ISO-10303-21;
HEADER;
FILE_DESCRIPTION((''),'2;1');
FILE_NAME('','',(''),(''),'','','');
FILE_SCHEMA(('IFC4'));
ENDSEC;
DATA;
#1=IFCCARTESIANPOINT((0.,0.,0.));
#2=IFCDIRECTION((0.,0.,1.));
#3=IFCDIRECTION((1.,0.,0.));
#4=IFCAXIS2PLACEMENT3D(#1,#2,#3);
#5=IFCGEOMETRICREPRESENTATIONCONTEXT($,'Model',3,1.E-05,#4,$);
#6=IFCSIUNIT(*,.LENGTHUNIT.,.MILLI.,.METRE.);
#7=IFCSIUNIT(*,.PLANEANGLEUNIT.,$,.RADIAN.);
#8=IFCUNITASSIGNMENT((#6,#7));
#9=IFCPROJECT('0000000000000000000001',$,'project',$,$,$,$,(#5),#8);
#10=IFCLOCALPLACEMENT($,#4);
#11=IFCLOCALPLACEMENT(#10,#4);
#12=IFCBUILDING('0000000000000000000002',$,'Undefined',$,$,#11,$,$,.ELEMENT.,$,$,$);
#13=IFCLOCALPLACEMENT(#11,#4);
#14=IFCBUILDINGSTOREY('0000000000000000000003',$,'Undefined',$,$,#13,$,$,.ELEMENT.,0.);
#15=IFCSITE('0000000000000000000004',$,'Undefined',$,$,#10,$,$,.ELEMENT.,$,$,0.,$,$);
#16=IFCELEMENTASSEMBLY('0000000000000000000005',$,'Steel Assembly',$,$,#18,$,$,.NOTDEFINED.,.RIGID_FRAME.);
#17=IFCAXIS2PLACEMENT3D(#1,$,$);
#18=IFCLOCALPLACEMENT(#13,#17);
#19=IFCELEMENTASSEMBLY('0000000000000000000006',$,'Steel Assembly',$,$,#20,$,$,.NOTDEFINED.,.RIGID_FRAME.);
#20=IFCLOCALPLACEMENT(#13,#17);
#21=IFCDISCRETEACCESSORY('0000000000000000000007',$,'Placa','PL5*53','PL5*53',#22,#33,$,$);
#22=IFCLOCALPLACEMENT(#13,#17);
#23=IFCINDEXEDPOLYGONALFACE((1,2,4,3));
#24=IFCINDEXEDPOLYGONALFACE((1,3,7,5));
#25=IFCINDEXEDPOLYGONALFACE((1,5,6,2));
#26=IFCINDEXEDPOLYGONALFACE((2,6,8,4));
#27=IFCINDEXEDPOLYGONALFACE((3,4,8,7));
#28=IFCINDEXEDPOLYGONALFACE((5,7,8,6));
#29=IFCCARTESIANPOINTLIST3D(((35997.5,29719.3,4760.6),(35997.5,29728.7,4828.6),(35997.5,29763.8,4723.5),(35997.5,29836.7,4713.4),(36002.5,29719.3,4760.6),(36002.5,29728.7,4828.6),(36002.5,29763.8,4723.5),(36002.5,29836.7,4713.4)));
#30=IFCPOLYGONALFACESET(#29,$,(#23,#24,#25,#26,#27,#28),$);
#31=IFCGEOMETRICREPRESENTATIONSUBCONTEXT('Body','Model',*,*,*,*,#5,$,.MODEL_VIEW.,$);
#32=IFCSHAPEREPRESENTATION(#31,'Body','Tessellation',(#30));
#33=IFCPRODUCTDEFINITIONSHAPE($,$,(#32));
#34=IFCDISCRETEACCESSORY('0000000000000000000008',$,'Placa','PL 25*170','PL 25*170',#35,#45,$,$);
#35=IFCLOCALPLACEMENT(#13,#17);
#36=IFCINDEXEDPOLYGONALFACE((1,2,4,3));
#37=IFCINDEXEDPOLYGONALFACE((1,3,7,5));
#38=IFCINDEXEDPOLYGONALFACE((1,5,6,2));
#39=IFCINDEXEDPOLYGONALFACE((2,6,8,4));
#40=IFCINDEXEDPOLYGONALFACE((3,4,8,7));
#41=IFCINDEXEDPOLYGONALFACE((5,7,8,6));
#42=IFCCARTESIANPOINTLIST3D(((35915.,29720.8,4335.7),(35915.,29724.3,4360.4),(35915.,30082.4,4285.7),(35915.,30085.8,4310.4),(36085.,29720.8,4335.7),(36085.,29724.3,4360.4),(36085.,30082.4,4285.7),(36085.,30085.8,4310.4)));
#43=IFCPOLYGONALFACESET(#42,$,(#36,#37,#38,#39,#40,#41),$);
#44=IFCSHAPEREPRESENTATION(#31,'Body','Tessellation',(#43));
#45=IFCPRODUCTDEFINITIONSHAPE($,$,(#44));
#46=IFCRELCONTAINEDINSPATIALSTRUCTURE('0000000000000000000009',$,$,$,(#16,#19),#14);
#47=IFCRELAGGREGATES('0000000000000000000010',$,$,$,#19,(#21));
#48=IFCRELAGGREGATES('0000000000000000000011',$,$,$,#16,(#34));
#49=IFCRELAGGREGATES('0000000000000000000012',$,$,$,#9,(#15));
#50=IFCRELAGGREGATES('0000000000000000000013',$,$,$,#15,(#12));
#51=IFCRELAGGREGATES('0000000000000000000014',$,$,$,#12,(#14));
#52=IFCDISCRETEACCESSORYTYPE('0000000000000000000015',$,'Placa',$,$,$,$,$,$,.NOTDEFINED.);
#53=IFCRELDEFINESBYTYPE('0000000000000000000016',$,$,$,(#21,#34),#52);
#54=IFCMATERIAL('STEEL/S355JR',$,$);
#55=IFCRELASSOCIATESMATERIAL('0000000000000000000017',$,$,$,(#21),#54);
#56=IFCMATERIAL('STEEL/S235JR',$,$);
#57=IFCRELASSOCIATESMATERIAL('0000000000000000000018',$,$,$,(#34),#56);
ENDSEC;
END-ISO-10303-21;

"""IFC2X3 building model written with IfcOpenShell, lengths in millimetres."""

from ifc_helpers import new_model, si_unit, frame, origin_with_axes, place, context, subcontext, project, spatial, polyline, outline, extrude, material, type_object, element, aggregate, save


model = new_model("IFC2X3")

# Units and contexts
model_context = context("Model", 3, precision=1e-05, world=origin_with_axes())
body_context = subcontext(model_context, "Body", "Model", "MODEL_VIEW")
ifc_project = project(units=[si_unit("LENGTHUNIT", "METRE", prefix="MILLI"), si_unit("PLANEANGLEUNIT", "RADIAN")], contexts=[model_context])

# Site, building, storey
site_placement = place(None, origin_with_axes())
site = spatial("IfcSite", under=ifc_project, at=site_placement, Name="Undefined", CompositionType="ELEMENT", RefElevation=0.0)
building_placement = place(site_placement, origin_with_axes())
building = spatial("IfcBuilding", under=site, at=building_placement, Name="Undefined", CompositionType="ELEMENT")
storey_placement = place(building_placement, origin_with_axes())
storey = spatial("IfcBuildingStorey", under=building, at=storey_placement, Name="Undefined", CompositionType="ELEMENT", Elevation=0.0)

# Shared definitions
ifc_material_1 = material(Name="STEEL/S355JR")

# Element assembly
assembly_1_placement = place(storey_placement, origin_with_axes())
assembly_1 = element("IfcElementAssembly", 1, at=assembly_1_placement, inside=storey, Name="Steel Assembly", AssemblyPlace="NOTDEFINED", PredefinedType="RIGID_FRAME")

# Shared definitions
ifc_material_2 = material(Name="STEEL/S235JR")

# Element assembly, discrete accessory
assembly_2_placement = place(storey_placement, origin_with_axes())
assembly_2 = element("IfcElementAssembly", 2, at=assembly_2_placement, inside=storey, Name="Steel Assembly", AssemblyPlace="NOTDEFINED", PredefinedType="RIGID_FRAME")
discrete_accessory_type_1 = type_object("IfcDiscreteAccessoryType", Name="Placa")
discrete_accessory_1_placement = place(assembly_2_placement, frame((36000.0, 29728.7, 4828.6), z_axis=(-1.0, 0.0, 0.0), x_axis=(0.0, 0.684057, -0.729429)))
discrete_accessory_1 = element("IfcDiscreteAccessory", 3, at=discrete_accessory_1_placement, type_object=discrete_accessory_type_1, material=ifc_material_1, Name="Placa", Description="PL5*53", ObjectType="PL5*53", context=body_context, shape_type="SweptSolid", body=[
    extrude(outline(polyline([(0.0, 0.0), (157.9, 0.0), (100.7, 46.3), (43.1, 53.3), (0.0, 0.0)])), frame((0.0, 0.0, -2.5), z_axis=(0.0, 0.0, 1.0), x_axis=(1.0, 0.0, 0.0)), (0.0, 0.0, 1.0), 5.0),
])

# Discrete accessory
discrete_accessory_2_placement = place(assembly_1_placement, frame((36085.0, 30084.1, 4298.1), z_axis=(0.0, -0.13698, -0.990574), x_axis=(0.0, -0.990574, 0.13698)))
discrete_accessory_2 = element("IfcDiscreteAccessory", 4, at=discrete_accessory_2_placement, type_object=discrete_accessory_type_1, material=ifc_material_2, Name="Placa", Description="PL 25*170", ObjectType="PL 25*170", context=body_context, shape_type="SweptSolid", body=[
    extrude(outline(polyline([(0.0, 0.0), (365.0, 0.0), (365.0, 170.0), (0.0, 170.0), (0.0, 0.0)])), frame((0.0, 0.0, -12.5), z_axis=(0.0, 0.0, 1.0), x_axis=(1.0, 0.0, 0.0)), (0.0, 0.0, 1.0), 25.0),
])

aggregate(assembly_2, [discrete_accessory_1])

aggregate(assembly_1, [discrete_accessory_2])

save(model, "model.ifc")
